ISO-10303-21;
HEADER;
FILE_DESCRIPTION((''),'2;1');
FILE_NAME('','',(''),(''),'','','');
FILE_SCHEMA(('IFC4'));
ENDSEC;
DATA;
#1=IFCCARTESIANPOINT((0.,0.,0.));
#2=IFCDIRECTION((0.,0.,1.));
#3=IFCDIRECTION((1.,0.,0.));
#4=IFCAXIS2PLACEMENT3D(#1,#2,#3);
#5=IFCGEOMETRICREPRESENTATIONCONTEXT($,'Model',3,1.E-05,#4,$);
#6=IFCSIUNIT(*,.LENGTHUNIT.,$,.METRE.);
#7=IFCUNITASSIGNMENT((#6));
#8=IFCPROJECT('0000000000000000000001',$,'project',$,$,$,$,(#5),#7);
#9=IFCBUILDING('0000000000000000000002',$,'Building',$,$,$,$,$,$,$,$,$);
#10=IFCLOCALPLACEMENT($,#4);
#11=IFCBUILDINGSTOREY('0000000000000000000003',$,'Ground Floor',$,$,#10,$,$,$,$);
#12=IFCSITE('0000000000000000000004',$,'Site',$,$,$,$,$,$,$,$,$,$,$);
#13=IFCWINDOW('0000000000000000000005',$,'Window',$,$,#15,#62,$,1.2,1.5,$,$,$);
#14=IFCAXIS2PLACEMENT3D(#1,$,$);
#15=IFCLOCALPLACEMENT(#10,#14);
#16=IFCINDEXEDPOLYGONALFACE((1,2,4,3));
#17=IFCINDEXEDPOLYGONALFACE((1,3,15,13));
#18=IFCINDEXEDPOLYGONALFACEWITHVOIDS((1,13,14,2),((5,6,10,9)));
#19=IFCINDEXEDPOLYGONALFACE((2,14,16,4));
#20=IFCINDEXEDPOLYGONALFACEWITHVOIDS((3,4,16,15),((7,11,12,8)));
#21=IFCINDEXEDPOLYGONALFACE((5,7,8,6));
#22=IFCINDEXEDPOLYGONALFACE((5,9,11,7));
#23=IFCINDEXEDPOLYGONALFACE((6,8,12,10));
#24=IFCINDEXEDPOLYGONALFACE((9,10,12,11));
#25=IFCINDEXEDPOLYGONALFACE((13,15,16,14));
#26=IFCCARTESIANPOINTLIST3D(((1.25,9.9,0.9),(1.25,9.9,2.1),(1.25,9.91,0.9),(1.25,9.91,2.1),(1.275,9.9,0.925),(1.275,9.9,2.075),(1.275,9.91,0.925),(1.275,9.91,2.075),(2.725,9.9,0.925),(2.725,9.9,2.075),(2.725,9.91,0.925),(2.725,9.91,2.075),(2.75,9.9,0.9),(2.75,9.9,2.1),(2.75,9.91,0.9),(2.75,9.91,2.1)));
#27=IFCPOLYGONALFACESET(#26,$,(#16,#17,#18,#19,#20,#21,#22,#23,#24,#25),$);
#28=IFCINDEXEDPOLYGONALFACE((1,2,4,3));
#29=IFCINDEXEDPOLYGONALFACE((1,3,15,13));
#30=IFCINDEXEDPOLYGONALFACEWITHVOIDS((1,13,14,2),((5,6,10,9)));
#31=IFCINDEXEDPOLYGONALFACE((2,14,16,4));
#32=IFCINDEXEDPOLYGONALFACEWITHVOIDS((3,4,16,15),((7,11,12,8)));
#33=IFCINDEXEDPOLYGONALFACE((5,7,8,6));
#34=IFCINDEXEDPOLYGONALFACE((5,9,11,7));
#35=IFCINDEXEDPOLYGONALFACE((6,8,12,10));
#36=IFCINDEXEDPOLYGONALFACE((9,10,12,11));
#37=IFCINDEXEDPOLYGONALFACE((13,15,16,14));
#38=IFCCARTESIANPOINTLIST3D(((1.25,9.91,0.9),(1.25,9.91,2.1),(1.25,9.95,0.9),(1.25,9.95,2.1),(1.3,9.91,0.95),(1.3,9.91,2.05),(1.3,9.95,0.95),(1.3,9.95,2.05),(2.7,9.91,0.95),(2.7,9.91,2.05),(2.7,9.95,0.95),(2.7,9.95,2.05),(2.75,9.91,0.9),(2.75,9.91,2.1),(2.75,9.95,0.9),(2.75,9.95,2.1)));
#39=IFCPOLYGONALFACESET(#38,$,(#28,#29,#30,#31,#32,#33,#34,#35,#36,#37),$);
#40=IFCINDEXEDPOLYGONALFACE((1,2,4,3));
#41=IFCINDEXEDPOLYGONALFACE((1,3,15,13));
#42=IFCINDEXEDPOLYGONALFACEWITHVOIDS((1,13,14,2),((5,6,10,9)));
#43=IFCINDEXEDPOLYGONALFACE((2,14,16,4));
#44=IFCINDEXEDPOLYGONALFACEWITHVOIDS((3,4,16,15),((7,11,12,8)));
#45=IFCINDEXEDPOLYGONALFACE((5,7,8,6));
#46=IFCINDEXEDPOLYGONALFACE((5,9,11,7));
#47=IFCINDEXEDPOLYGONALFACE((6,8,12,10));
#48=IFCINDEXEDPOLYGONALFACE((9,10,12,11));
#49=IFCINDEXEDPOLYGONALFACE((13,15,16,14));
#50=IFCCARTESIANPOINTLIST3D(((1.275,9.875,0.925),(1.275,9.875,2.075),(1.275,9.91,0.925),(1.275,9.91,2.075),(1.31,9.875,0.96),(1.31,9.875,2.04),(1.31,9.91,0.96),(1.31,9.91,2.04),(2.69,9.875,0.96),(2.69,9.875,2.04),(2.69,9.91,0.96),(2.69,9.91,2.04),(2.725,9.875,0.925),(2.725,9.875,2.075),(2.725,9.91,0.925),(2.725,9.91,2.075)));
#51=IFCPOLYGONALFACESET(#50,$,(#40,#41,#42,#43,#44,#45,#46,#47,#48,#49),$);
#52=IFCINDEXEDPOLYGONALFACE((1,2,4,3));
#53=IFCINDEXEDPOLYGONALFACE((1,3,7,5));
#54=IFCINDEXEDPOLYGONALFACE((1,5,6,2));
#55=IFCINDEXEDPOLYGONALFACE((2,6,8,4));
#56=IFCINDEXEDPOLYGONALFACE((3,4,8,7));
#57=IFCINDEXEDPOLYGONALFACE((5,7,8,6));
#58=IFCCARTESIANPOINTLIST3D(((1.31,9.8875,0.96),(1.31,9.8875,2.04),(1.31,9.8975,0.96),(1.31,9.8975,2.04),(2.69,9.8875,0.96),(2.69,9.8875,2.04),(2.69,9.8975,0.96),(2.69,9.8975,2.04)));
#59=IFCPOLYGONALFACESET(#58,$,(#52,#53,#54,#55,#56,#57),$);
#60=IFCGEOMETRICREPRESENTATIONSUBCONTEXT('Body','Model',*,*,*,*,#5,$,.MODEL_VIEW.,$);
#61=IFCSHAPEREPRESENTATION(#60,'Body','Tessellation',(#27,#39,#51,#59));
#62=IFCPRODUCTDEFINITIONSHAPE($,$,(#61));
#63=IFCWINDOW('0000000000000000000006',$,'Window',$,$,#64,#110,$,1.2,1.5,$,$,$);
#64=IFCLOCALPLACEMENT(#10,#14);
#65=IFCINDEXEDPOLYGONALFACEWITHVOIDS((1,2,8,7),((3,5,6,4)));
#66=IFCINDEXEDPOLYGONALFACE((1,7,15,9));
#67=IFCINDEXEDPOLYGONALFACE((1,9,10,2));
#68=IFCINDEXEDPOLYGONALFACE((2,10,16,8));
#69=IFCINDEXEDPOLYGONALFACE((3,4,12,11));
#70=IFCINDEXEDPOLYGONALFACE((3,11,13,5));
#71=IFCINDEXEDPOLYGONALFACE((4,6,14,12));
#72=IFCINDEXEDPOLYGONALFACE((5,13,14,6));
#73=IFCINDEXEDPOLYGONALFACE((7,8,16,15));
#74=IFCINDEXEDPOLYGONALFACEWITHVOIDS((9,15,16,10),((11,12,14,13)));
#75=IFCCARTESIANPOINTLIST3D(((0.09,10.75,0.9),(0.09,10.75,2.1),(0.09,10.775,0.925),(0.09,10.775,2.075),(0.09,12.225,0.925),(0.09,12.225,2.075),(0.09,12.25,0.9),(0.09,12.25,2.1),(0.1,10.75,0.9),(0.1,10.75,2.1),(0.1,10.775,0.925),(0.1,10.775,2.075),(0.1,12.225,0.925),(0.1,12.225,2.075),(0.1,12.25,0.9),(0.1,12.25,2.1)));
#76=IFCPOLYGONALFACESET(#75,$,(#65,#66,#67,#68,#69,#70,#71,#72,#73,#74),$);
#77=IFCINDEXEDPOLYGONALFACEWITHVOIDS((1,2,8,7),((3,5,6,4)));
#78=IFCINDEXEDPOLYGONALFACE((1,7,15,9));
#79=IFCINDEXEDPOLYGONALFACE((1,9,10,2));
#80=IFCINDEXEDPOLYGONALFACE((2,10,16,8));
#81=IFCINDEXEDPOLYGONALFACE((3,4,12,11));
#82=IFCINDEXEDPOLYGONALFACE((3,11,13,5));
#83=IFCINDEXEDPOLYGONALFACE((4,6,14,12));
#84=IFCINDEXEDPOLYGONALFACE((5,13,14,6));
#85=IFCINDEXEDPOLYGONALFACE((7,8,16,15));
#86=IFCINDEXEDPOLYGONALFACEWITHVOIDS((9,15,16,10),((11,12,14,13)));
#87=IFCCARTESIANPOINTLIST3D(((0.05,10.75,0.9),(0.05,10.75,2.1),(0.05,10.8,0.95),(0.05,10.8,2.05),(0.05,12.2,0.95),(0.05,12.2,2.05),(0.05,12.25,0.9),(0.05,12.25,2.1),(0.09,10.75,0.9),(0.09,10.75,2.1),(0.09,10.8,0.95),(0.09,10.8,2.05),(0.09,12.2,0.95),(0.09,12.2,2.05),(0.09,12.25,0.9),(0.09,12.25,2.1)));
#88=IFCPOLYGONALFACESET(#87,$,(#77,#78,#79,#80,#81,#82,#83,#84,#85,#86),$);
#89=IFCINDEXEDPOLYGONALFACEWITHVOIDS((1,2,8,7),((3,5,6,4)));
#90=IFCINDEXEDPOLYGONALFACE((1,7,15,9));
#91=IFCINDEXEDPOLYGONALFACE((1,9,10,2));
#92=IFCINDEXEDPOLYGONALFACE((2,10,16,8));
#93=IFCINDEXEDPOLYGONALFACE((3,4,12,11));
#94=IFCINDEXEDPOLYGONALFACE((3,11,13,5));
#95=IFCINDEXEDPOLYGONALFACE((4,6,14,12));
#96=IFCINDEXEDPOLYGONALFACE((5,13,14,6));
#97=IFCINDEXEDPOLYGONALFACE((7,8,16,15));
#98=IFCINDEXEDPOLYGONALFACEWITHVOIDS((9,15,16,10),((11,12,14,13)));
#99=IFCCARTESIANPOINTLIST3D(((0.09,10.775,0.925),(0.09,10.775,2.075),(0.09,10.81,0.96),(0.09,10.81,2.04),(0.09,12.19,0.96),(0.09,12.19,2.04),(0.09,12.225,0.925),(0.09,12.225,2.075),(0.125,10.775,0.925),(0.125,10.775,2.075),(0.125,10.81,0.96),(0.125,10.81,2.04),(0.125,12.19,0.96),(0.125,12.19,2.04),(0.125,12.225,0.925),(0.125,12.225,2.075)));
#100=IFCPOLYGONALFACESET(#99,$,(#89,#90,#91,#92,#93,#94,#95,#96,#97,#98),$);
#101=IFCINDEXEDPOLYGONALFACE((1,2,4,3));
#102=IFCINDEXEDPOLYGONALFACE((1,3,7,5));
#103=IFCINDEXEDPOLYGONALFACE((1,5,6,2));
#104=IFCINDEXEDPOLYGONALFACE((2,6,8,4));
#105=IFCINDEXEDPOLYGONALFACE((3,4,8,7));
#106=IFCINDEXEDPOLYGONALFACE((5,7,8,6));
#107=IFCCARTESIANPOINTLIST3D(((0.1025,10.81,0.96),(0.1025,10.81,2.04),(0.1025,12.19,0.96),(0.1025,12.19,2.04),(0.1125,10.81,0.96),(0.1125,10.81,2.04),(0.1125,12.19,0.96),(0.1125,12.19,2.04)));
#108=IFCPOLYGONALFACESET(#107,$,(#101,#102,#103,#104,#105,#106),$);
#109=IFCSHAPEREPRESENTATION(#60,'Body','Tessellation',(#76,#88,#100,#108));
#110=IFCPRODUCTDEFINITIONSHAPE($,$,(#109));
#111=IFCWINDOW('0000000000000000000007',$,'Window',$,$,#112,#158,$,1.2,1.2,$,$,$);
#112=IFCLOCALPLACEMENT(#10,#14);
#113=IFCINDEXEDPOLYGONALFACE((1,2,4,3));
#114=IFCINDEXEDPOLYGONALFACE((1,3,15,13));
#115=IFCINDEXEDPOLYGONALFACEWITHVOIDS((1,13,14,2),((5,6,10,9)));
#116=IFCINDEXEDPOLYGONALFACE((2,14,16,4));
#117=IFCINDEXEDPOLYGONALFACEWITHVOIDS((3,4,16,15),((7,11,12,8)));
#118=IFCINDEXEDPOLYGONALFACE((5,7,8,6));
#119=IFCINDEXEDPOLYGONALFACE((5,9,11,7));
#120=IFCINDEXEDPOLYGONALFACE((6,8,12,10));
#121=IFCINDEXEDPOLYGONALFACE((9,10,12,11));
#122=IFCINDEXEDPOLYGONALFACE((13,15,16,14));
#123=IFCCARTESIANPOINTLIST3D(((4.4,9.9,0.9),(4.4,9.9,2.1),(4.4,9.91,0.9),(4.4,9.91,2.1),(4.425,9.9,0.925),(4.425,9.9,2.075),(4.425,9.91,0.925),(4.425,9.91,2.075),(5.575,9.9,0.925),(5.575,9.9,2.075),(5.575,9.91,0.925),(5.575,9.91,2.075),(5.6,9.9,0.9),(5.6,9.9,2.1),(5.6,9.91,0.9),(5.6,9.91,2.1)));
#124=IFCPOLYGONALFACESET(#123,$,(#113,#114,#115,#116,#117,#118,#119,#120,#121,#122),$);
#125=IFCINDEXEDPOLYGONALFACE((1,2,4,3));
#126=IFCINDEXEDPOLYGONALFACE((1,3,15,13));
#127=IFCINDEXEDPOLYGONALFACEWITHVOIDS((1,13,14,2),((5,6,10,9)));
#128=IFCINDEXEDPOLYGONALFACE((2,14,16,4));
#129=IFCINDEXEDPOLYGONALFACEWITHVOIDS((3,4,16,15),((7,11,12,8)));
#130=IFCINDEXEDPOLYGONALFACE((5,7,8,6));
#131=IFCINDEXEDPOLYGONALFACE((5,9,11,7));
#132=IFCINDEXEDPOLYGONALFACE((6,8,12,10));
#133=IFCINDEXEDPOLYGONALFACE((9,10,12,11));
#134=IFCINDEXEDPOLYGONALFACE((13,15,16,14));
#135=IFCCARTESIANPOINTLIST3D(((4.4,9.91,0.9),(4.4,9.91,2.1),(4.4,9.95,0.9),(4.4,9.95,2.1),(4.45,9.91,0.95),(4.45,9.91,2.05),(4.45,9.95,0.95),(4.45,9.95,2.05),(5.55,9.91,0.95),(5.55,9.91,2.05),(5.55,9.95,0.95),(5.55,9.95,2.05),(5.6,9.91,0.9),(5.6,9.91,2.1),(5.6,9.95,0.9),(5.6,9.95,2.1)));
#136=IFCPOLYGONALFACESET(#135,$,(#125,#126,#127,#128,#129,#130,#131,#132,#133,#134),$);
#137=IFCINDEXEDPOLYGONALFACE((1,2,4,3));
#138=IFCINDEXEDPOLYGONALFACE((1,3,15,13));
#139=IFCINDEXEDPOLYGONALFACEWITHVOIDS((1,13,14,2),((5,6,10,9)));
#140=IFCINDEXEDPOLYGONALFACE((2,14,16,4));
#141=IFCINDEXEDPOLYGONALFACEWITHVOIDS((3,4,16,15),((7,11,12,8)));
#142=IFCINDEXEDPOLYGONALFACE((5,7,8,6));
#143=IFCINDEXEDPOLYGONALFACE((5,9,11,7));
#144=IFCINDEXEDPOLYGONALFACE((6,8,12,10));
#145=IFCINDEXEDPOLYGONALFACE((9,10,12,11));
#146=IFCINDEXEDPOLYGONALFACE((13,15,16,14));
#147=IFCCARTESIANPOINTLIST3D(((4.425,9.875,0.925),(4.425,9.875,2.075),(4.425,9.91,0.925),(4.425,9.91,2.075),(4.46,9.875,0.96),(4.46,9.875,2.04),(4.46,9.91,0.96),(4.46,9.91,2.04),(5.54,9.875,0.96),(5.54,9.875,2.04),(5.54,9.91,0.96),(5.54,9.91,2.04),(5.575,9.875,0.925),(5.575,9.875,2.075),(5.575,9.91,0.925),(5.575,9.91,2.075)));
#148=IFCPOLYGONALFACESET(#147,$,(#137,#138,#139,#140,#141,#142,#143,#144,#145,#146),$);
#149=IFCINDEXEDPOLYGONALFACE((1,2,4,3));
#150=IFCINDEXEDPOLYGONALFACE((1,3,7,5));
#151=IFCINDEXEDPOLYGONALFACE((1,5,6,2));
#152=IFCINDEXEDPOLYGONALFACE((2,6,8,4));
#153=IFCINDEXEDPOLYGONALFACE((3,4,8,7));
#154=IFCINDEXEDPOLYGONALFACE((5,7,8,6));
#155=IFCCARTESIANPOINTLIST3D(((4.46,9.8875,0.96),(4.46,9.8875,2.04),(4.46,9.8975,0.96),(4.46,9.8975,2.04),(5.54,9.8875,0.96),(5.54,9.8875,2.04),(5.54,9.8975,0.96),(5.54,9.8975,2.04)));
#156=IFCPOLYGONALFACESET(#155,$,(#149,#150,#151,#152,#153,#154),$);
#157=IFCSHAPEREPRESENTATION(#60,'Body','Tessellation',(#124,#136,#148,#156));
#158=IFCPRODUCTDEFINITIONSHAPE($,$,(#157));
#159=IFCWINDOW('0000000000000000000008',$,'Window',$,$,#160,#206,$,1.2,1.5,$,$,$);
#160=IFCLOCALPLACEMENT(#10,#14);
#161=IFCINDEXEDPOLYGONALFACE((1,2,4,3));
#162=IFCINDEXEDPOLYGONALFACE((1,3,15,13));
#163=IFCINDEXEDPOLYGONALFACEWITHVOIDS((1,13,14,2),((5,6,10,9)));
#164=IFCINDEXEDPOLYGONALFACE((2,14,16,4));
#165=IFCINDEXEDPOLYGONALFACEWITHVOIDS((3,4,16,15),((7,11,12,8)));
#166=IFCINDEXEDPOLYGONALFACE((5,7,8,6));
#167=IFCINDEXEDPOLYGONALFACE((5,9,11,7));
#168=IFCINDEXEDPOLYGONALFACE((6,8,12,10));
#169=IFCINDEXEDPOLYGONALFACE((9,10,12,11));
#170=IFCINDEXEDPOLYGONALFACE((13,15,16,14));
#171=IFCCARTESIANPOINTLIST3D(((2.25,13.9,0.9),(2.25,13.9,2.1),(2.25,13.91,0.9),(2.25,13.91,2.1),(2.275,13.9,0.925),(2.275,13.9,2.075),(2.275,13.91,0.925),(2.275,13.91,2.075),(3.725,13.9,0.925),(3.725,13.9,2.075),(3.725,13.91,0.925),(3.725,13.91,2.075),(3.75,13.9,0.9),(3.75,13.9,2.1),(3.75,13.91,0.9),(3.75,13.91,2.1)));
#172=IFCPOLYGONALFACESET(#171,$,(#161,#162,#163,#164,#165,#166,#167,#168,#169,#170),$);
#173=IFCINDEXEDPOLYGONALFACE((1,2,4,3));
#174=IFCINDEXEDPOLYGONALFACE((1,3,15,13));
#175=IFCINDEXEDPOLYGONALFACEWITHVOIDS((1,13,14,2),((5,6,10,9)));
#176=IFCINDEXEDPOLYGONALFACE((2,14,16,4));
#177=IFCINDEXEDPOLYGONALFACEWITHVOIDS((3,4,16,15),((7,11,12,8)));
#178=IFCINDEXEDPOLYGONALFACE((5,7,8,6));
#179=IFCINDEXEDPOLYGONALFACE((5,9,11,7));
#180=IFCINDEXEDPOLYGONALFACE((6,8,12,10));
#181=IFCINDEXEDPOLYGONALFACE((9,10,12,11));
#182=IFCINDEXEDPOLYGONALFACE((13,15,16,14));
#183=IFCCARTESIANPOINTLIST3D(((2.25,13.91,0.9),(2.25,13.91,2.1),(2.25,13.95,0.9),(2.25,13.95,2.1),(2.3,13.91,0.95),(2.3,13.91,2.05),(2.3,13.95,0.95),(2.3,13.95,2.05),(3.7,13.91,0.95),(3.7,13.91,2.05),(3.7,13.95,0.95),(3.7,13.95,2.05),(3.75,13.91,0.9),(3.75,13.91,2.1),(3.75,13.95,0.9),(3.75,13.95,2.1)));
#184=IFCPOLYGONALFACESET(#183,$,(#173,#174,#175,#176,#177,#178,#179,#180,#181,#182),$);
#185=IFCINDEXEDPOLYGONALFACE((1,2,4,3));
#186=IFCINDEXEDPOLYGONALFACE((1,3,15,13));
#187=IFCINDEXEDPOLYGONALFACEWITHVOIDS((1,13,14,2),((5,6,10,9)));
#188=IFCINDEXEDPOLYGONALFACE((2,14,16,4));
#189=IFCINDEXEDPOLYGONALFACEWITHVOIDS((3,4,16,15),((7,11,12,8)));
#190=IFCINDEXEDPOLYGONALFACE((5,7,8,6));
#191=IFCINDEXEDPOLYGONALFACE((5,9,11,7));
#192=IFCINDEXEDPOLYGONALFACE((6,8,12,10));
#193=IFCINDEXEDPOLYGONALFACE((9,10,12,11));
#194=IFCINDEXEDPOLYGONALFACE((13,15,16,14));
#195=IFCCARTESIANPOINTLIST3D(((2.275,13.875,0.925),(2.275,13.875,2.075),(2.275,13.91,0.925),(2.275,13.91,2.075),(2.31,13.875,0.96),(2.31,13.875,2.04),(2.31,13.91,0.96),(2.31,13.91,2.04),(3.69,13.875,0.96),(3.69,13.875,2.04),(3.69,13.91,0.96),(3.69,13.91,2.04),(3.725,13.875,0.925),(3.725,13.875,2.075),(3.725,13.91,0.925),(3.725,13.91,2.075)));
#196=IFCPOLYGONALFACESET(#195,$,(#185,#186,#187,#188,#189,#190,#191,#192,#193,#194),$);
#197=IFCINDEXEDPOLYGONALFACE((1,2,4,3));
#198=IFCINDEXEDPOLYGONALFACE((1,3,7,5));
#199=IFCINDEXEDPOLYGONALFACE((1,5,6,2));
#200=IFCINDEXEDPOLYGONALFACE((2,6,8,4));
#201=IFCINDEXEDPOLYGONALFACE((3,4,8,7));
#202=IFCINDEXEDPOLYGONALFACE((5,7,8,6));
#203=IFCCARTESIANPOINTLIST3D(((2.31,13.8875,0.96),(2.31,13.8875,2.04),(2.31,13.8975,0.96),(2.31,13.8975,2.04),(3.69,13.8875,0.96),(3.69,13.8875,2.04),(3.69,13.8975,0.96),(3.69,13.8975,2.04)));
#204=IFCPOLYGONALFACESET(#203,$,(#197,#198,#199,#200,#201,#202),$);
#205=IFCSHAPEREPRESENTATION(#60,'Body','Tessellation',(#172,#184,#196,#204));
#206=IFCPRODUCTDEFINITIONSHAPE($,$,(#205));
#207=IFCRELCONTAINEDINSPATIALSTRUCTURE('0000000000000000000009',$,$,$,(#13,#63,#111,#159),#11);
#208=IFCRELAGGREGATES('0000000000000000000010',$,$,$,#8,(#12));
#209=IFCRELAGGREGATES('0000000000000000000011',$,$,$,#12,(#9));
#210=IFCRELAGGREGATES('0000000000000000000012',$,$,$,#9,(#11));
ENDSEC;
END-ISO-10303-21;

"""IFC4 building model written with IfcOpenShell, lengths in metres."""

from ifc_helpers import new_model, si_unit, frame, origin_with_axes, place, context, subcontext, project, spatial, line, indexed_curve, outline, extrude, element, save


model = new_model("IFC4")

# Units and contexts
model_context = context("Model", 3, precision=1e-05, world=origin_with_axes())
body_context = subcontext(model_context, "Body", "Model", "MODEL_VIEW")
ifc_project = project(units=[si_unit("LENGTHUNIT", "METRE")], contexts=[model_context])

# Site, building, storey
site = spatial("IfcSite", under=ifc_project, Name="Site")
building = spatial("IfcBuilding", under=site, Name="Building")
storey_placement = place(None, origin_with_axes())
storey = spatial("IfcBuildingStorey", under=building, at=storey_placement, Name="Ground Floor")

# Windows
for number, where, z_axis, x_axis, name in (
    (1, (2.75, 10.0, 0.9), (0.0, 0.0, 1.0), (-1.0, 0.0, 0.0), "Window"),
    (2, (0.0, 12.25, 0.9), (0.0, 0.0, 1.0), (0.0, -1.0, 0.0), "Window"),
):
    element("IfcWindow", number, at=place(storey_placement, frame(where, z_axis=z_axis, x_axis=x_axis)), inside=storey, Name=name, OverallHeight=1.2, OverallWidth=1.5, context=body_context, shape_type="SweptSolid", body=[
        extrude(outline(indexed_curve([(0.0, 0.0), (1.5, 0.0), (1.5, 1.2), (0.0, 1.2)], segments=[line(1, 2, 3, 4, 1)]), holes=[indexed_curve([(0.025, 0.025), (1.475, 0.025), (1.475, 1.175), (0.025, 1.175)], segments=[line(1, 2, 3, 4, 1)])]), frame((0.0, 0.09, 0.0), z_axis=(0.0, -1.0, 0.0), x_axis=(1.0, 0.0, 0.0)), (0.0, 0.0, -1.0), 0.01),
        extrude(outline(indexed_curve([(0.0, 0.0), (1.5, 0.0), (1.5, 1.2), (0.0, 1.2)], segments=[line(1, 2, 3, 4, 1)]), holes=[indexed_curve([(0.05, 0.05), (1.45, 0.05), (1.45, 1.15), (0.05, 1.15)], segments=[line(1, 2, 3, 4, 1)])]), frame((0.0, 0.05, 0.0), z_axis=(0.0, -1.0, 0.0), x_axis=(1.0, 0.0, 0.0)), (0.0, 0.0, -1.0), 0.04),
        extrude(outline(indexed_curve([(0.0, 0.0), (1.45, 0.0), (1.45, 1.15), (0.0, 1.15)], segments=[line(1, 2, 3, 4, 1)]), holes=[indexed_curve([(0.035, 0.035), (1.415, 0.035), (1.415, 1.115), (0.035, 1.115)], segments=[line(1, 2, 3, 4, 1)])]), frame((0.025, 0.09, 0.025), z_axis=(0.0, -1.0, 0.0), x_axis=(1.0, 0.0, 0.0)), (0.0, 0.0, -1.0), 0.035),
        extrude(outline(indexed_curve([(0.035, 0.035), (1.415, 0.035), (1.415, 1.115), (0.035, 1.115)], segments=[line(1, 2, 3, 4, 1)])), frame((0.025, 0.1025, 0.025), z_axis=(0.0, -1.0, 0.0), x_axis=(1.0, 0.0, 0.0)), (0.0, 0.0, -1.0), 0.01),
    ])
window_1_placement = place(storey_placement, frame((5.6, 10.0, 0.9), z_axis=(0.0, 0.0, 1.0), x_axis=(-1.0, 0.0, 0.0)))
element("IfcWindow", 3, at=window_1_placement, inside=storey, Name="Window", OverallHeight=1.2, OverallWidth=1.2, context=body_context, shape_type="SweptSolid", body=[
    extrude(outline(indexed_curve([(0.0, 0.0), (1.2, 0.0), (1.2, 1.2), (0.0, 1.2)], segments=[line(1, 2, 3, 4, 1)]), holes=[indexed_curve([(0.025, 0.025), (1.175, 0.025), (1.175, 1.175), (0.025, 1.175)], segments=[line(1, 2, 3, 4, 1)])]), frame((0.0, 0.09, 0.0), z_axis=(0.0, -1.0, 0.0), x_axis=(1.0, 0.0, 0.0)), (0.0, 0.0, -1.0), 0.01),
    extrude(outline(indexed_curve([(0.0, 0.0), (1.2, 0.0), (1.2, 1.2), (0.0, 1.2)], segments=[line(1, 2, 3, 4, 1)]), holes=[indexed_curve([(0.05, 0.05), (1.15, 0.05), (1.15, 1.15), (0.05, 1.15)], segments=[line(1, 2, 3, 4, 1)])]), frame((0.0, 0.05, 0.0), z_axis=(0.0, -1.0, 0.0), x_axis=(1.0, 0.0, 0.0)), (0.0, 0.0, -1.0), 0.04),
    extrude(outline(indexed_curve([(0.0, 0.0), (1.15, 0.0), (1.15, 1.15), (0.0, 1.15)], segments=[line(1, 2, 3, 4, 1)]), holes=[indexed_curve([(0.035, 0.035), (1.115, 0.035), (1.115, 1.115), (0.035, 1.115)], segments=[line(1, 2, 3, 4, 1)])]), frame((0.025, 0.09, 0.025), z_axis=(0.0, -1.0, 0.0), x_axis=(1.0, 0.0, 0.0)), (0.0, 0.0, -1.0), 0.035),
    extrude(outline(indexed_curve([(0.035, 0.035), (1.115, 0.035), (1.115, 1.115), (0.035, 1.115)], segments=[line(1, 2, 3, 4, 1)])), frame((0.025, 0.1025, 0.025), z_axis=(0.0, -1.0, 0.0), x_axis=(1.0, 0.0, 0.0)), (0.0, 0.0, -1.0), 0.01),
])
window_2_placement = place(storey_placement, frame((3.75, 14.0, 0.9), z_axis=(0.0, 0.0, 1.0), x_axis=(-1.0, 0.0, 0.0)))
element("IfcWindow", 4, at=window_2_placement, inside=storey, Name="Window", OverallHeight=1.2, OverallWidth=1.5, context=body_context, shape_type="SweptSolid", body=[
    extrude(outline(indexed_curve([(0.0, 0.0), (1.5, 0.0), (1.5, 1.2), (0.0, 1.2)], segments=[line(1, 2, 3, 4, 1)]), holes=[indexed_curve([(0.025, 0.025), (1.475, 0.025), (1.475, 1.175), (0.025, 1.175)], segments=[line(1, 2, 3, 4, 1)])]), frame((0.0, 0.09, 0.0), z_axis=(0.0, -1.0, 0.0), x_axis=(1.0, 0.0, 0.0)), (0.0, 0.0, -1.0), 0.01),
    extrude(outline(indexed_curve([(0.0, 0.0), (1.5, 0.0), (1.5, 1.2), (0.0, 1.2)], segments=[line(1, 2, 3, 4, 1)]), holes=[indexed_curve([(0.05, 0.05), (1.45, 0.05), (1.45, 1.15), (0.05, 1.15)], segments=[line(1, 2, 3, 4, 1)])]), frame((0.0, 0.05, 0.0), z_axis=(0.0, -1.0, 0.0), x_axis=(1.0, 0.0, 0.0)), (0.0, 0.0, -1.0), 0.04),
    extrude(outline(indexed_curve([(0.0, 0.0), (1.45, 0.0), (1.45, 1.15), (0.0, 1.15)], segments=[line(1, 2, 3, 4, 1)]), holes=[indexed_curve([(0.035, 0.035), (1.415, 0.035), (1.415, 1.115), (0.035, 1.115)], segments=[line(1, 2, 3, 4, 1)])]), frame((0.025, 0.09, 0.025), z_axis=(0.0, -1.0, 0.0), x_axis=(1.0, 0.0, 0.0)), (0.0, 0.0, -1.0), 0.035),
    extrude(outline(indexed_curve([(0.035, 0.035), (1.415, 0.035), (1.415, 1.115), (0.035, 1.115)], segments=[line(1, 2, 3, 4, 1)])), frame((0.025, 0.1025, 0.025), z_axis=(0.0, -1.0, 0.0), x_axis=(1.0, 0.0, 0.0)), (0.0, 0.0, -1.0), 0.01),
])

save(model, "model.ifc")
